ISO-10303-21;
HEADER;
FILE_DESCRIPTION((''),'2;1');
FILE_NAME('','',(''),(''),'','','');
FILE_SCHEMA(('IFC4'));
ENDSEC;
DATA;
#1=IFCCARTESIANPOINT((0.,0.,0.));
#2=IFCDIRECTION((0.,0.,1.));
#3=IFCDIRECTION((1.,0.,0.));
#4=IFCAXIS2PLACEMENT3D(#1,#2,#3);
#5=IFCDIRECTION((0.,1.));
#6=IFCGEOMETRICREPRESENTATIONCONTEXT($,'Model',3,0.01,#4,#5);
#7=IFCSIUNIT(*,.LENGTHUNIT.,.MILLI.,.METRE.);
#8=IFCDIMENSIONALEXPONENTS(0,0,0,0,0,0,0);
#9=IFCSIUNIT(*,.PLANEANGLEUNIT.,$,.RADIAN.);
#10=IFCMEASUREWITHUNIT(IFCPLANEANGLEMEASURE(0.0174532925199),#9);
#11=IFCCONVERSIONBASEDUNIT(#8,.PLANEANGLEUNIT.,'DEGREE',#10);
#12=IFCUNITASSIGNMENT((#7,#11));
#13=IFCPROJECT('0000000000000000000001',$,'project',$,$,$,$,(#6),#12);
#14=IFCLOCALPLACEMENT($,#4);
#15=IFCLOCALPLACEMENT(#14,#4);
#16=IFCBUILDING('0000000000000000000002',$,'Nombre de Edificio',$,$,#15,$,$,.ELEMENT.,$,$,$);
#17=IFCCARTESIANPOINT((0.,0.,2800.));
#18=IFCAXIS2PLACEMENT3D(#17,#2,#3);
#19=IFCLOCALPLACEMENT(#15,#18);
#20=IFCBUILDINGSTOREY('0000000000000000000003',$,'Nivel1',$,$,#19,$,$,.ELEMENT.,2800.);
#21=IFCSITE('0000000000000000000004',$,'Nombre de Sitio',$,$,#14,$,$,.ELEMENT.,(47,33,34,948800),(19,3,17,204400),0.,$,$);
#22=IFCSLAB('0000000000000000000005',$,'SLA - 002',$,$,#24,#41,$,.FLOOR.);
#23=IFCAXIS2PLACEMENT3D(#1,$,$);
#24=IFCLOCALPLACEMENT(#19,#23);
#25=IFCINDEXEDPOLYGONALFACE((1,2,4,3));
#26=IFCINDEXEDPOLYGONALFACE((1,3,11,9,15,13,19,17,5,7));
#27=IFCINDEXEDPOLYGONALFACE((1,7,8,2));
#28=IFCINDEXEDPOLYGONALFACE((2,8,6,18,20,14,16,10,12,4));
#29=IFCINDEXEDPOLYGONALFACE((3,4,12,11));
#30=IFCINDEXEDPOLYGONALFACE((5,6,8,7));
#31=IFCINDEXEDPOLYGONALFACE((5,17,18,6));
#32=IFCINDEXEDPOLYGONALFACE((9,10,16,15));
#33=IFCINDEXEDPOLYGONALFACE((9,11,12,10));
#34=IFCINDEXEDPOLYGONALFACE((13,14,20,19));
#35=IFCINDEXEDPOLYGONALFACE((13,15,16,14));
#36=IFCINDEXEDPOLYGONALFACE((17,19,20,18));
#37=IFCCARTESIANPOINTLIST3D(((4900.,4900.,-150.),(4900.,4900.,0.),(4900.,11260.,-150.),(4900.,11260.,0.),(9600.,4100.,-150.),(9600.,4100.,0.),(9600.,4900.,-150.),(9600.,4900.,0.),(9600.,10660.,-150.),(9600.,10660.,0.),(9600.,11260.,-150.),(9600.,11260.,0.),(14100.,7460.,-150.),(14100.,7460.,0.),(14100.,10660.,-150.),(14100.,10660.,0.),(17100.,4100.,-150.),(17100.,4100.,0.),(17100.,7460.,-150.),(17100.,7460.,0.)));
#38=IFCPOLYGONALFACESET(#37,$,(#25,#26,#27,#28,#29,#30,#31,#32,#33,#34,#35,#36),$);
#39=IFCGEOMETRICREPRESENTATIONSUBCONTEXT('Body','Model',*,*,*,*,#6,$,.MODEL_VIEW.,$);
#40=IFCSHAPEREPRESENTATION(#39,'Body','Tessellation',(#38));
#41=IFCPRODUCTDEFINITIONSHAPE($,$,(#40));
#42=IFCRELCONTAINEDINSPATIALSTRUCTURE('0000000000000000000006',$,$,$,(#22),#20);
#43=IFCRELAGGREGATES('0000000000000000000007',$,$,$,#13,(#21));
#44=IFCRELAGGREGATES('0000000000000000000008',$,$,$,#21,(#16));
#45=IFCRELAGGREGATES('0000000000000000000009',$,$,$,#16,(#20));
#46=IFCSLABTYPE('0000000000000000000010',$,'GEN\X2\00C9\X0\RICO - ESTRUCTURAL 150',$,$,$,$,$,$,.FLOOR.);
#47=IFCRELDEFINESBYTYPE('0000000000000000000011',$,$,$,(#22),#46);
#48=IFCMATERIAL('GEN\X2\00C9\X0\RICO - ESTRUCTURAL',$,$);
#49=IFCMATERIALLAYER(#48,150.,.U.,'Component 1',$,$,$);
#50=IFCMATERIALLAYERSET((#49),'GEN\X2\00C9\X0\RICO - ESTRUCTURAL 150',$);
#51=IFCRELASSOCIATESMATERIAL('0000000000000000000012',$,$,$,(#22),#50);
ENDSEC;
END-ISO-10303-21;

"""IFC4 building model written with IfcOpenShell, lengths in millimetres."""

from ifc_helpers import new_model, entity, si_unit, converted_unit, direction, frame, origin_with_axes, place, context, subcontext, project, spatial, line, indexed_curve, outline, extrude, material, layer, layer_set, layer_usage, type_object, element, save


model = new_model("IFC4")

# Units and contexts
model_context = context("Model", 3, precision=0.01, world=origin_with_axes(), true_north=direction((0.0, 1.0)))
body_context = subcontext(model_context, "Body", "Model", "MODEL_VIEW")
ifc_project = project(units=[si_unit("LENGTHUNIT", "METRE", prefix="MILLI"), converted_unit("PLANEANGLEUNIT", "DEGREE", entity("IfcPlaneAngleMeasure", 0.0174532925199), si_unit("PLANEANGLEUNIT", "RADIAN"), dimensions=[0, 0, 0, 0, 0, 0, 0])], contexts=[model_context])

# Site, building, storey
site_placement = place(None, origin_with_axes())
site = spatial("IfcSite", under=ifc_project, at=site_placement, Name="Nombre de Sitio", CompositionType="ELEMENT", RefLatitude=(47, 33, 34, 948800), RefLongitude=(19, 3, 17, 204400), RefElevation=0.0)
building_placement = place(site_placement, origin_with_axes())
building = spatial("IfcBuilding", under=site, at=building_placement, Name="Nombre de Edificio", CompositionType="ELEMENT")
storey_placement = place(building_placement, frame((0.0, 0.0, 2800.0), z_axis=(0.0, 0.0, 1.0), x_axis=(1.0, 0.0, 0.0)))
storey = spatial("IfcBuildingStorey", under=building, at=storey_placement, Name="Nivel1", CompositionType="ELEMENT", Elevation=2800.0)

# Slab
ifc_material = material(Name="GENÉRICO - ESTRUCTURAL")
ifc_layer = layer(ifc_material, 150.0, ventilated="UNKNOWN", Name="Component 1")
ifc_layer_set = layer_set([ifc_layer], Name="GENÉRICO - ESTRUCTURAL 150")
ifc_layer_usage = layer_usage(ifc_layer_set, "AXIS3", "NEGATIVE", 150.0)
slab_type = type_object("IfcSlabType", Name="GENÉRICO - ESTRUCTURAL 150", PredefinedType="FLOOR")
slab_placement = place(storey_placement, frame((4900.0, 4900.0, 0.0), z_axis=(0.0, 0.0, 1.0), x_axis=(1.0, 0.0, 0.0)))
element("IfcSlab", 1, at=slab_placement, inside=storey, type_object=slab_type, material=ifc_layer_usage, Name="SLA - 002", PredefinedType="FLOOR", context=body_context, shape_type="SweptSolid", body=[
    extrude(outline(indexed_curve([(0.0, 0.0), (4700.0, 0.0), (4700.0, -800.0), (12200.0, -800.0), (12200.0, 2560.0), (9200.0, 2560.0), (9200.0, 5760.0), (4700.0, 5760.0), (4700.0, 6360.0), (0.0, 6360.0)], segments=[line(1, 2, 3, 4, 5, 6, 7, 8, 9, 10, 1)])), frame((0.0, 0.0, -150.0), z_axis=(0.0, 0.0, 1.0), x_axis=(1.0, 0.0, 0.0)), (0.0, 0.0, 1.0), 150.0),
])

save(model, "model.ifc")
